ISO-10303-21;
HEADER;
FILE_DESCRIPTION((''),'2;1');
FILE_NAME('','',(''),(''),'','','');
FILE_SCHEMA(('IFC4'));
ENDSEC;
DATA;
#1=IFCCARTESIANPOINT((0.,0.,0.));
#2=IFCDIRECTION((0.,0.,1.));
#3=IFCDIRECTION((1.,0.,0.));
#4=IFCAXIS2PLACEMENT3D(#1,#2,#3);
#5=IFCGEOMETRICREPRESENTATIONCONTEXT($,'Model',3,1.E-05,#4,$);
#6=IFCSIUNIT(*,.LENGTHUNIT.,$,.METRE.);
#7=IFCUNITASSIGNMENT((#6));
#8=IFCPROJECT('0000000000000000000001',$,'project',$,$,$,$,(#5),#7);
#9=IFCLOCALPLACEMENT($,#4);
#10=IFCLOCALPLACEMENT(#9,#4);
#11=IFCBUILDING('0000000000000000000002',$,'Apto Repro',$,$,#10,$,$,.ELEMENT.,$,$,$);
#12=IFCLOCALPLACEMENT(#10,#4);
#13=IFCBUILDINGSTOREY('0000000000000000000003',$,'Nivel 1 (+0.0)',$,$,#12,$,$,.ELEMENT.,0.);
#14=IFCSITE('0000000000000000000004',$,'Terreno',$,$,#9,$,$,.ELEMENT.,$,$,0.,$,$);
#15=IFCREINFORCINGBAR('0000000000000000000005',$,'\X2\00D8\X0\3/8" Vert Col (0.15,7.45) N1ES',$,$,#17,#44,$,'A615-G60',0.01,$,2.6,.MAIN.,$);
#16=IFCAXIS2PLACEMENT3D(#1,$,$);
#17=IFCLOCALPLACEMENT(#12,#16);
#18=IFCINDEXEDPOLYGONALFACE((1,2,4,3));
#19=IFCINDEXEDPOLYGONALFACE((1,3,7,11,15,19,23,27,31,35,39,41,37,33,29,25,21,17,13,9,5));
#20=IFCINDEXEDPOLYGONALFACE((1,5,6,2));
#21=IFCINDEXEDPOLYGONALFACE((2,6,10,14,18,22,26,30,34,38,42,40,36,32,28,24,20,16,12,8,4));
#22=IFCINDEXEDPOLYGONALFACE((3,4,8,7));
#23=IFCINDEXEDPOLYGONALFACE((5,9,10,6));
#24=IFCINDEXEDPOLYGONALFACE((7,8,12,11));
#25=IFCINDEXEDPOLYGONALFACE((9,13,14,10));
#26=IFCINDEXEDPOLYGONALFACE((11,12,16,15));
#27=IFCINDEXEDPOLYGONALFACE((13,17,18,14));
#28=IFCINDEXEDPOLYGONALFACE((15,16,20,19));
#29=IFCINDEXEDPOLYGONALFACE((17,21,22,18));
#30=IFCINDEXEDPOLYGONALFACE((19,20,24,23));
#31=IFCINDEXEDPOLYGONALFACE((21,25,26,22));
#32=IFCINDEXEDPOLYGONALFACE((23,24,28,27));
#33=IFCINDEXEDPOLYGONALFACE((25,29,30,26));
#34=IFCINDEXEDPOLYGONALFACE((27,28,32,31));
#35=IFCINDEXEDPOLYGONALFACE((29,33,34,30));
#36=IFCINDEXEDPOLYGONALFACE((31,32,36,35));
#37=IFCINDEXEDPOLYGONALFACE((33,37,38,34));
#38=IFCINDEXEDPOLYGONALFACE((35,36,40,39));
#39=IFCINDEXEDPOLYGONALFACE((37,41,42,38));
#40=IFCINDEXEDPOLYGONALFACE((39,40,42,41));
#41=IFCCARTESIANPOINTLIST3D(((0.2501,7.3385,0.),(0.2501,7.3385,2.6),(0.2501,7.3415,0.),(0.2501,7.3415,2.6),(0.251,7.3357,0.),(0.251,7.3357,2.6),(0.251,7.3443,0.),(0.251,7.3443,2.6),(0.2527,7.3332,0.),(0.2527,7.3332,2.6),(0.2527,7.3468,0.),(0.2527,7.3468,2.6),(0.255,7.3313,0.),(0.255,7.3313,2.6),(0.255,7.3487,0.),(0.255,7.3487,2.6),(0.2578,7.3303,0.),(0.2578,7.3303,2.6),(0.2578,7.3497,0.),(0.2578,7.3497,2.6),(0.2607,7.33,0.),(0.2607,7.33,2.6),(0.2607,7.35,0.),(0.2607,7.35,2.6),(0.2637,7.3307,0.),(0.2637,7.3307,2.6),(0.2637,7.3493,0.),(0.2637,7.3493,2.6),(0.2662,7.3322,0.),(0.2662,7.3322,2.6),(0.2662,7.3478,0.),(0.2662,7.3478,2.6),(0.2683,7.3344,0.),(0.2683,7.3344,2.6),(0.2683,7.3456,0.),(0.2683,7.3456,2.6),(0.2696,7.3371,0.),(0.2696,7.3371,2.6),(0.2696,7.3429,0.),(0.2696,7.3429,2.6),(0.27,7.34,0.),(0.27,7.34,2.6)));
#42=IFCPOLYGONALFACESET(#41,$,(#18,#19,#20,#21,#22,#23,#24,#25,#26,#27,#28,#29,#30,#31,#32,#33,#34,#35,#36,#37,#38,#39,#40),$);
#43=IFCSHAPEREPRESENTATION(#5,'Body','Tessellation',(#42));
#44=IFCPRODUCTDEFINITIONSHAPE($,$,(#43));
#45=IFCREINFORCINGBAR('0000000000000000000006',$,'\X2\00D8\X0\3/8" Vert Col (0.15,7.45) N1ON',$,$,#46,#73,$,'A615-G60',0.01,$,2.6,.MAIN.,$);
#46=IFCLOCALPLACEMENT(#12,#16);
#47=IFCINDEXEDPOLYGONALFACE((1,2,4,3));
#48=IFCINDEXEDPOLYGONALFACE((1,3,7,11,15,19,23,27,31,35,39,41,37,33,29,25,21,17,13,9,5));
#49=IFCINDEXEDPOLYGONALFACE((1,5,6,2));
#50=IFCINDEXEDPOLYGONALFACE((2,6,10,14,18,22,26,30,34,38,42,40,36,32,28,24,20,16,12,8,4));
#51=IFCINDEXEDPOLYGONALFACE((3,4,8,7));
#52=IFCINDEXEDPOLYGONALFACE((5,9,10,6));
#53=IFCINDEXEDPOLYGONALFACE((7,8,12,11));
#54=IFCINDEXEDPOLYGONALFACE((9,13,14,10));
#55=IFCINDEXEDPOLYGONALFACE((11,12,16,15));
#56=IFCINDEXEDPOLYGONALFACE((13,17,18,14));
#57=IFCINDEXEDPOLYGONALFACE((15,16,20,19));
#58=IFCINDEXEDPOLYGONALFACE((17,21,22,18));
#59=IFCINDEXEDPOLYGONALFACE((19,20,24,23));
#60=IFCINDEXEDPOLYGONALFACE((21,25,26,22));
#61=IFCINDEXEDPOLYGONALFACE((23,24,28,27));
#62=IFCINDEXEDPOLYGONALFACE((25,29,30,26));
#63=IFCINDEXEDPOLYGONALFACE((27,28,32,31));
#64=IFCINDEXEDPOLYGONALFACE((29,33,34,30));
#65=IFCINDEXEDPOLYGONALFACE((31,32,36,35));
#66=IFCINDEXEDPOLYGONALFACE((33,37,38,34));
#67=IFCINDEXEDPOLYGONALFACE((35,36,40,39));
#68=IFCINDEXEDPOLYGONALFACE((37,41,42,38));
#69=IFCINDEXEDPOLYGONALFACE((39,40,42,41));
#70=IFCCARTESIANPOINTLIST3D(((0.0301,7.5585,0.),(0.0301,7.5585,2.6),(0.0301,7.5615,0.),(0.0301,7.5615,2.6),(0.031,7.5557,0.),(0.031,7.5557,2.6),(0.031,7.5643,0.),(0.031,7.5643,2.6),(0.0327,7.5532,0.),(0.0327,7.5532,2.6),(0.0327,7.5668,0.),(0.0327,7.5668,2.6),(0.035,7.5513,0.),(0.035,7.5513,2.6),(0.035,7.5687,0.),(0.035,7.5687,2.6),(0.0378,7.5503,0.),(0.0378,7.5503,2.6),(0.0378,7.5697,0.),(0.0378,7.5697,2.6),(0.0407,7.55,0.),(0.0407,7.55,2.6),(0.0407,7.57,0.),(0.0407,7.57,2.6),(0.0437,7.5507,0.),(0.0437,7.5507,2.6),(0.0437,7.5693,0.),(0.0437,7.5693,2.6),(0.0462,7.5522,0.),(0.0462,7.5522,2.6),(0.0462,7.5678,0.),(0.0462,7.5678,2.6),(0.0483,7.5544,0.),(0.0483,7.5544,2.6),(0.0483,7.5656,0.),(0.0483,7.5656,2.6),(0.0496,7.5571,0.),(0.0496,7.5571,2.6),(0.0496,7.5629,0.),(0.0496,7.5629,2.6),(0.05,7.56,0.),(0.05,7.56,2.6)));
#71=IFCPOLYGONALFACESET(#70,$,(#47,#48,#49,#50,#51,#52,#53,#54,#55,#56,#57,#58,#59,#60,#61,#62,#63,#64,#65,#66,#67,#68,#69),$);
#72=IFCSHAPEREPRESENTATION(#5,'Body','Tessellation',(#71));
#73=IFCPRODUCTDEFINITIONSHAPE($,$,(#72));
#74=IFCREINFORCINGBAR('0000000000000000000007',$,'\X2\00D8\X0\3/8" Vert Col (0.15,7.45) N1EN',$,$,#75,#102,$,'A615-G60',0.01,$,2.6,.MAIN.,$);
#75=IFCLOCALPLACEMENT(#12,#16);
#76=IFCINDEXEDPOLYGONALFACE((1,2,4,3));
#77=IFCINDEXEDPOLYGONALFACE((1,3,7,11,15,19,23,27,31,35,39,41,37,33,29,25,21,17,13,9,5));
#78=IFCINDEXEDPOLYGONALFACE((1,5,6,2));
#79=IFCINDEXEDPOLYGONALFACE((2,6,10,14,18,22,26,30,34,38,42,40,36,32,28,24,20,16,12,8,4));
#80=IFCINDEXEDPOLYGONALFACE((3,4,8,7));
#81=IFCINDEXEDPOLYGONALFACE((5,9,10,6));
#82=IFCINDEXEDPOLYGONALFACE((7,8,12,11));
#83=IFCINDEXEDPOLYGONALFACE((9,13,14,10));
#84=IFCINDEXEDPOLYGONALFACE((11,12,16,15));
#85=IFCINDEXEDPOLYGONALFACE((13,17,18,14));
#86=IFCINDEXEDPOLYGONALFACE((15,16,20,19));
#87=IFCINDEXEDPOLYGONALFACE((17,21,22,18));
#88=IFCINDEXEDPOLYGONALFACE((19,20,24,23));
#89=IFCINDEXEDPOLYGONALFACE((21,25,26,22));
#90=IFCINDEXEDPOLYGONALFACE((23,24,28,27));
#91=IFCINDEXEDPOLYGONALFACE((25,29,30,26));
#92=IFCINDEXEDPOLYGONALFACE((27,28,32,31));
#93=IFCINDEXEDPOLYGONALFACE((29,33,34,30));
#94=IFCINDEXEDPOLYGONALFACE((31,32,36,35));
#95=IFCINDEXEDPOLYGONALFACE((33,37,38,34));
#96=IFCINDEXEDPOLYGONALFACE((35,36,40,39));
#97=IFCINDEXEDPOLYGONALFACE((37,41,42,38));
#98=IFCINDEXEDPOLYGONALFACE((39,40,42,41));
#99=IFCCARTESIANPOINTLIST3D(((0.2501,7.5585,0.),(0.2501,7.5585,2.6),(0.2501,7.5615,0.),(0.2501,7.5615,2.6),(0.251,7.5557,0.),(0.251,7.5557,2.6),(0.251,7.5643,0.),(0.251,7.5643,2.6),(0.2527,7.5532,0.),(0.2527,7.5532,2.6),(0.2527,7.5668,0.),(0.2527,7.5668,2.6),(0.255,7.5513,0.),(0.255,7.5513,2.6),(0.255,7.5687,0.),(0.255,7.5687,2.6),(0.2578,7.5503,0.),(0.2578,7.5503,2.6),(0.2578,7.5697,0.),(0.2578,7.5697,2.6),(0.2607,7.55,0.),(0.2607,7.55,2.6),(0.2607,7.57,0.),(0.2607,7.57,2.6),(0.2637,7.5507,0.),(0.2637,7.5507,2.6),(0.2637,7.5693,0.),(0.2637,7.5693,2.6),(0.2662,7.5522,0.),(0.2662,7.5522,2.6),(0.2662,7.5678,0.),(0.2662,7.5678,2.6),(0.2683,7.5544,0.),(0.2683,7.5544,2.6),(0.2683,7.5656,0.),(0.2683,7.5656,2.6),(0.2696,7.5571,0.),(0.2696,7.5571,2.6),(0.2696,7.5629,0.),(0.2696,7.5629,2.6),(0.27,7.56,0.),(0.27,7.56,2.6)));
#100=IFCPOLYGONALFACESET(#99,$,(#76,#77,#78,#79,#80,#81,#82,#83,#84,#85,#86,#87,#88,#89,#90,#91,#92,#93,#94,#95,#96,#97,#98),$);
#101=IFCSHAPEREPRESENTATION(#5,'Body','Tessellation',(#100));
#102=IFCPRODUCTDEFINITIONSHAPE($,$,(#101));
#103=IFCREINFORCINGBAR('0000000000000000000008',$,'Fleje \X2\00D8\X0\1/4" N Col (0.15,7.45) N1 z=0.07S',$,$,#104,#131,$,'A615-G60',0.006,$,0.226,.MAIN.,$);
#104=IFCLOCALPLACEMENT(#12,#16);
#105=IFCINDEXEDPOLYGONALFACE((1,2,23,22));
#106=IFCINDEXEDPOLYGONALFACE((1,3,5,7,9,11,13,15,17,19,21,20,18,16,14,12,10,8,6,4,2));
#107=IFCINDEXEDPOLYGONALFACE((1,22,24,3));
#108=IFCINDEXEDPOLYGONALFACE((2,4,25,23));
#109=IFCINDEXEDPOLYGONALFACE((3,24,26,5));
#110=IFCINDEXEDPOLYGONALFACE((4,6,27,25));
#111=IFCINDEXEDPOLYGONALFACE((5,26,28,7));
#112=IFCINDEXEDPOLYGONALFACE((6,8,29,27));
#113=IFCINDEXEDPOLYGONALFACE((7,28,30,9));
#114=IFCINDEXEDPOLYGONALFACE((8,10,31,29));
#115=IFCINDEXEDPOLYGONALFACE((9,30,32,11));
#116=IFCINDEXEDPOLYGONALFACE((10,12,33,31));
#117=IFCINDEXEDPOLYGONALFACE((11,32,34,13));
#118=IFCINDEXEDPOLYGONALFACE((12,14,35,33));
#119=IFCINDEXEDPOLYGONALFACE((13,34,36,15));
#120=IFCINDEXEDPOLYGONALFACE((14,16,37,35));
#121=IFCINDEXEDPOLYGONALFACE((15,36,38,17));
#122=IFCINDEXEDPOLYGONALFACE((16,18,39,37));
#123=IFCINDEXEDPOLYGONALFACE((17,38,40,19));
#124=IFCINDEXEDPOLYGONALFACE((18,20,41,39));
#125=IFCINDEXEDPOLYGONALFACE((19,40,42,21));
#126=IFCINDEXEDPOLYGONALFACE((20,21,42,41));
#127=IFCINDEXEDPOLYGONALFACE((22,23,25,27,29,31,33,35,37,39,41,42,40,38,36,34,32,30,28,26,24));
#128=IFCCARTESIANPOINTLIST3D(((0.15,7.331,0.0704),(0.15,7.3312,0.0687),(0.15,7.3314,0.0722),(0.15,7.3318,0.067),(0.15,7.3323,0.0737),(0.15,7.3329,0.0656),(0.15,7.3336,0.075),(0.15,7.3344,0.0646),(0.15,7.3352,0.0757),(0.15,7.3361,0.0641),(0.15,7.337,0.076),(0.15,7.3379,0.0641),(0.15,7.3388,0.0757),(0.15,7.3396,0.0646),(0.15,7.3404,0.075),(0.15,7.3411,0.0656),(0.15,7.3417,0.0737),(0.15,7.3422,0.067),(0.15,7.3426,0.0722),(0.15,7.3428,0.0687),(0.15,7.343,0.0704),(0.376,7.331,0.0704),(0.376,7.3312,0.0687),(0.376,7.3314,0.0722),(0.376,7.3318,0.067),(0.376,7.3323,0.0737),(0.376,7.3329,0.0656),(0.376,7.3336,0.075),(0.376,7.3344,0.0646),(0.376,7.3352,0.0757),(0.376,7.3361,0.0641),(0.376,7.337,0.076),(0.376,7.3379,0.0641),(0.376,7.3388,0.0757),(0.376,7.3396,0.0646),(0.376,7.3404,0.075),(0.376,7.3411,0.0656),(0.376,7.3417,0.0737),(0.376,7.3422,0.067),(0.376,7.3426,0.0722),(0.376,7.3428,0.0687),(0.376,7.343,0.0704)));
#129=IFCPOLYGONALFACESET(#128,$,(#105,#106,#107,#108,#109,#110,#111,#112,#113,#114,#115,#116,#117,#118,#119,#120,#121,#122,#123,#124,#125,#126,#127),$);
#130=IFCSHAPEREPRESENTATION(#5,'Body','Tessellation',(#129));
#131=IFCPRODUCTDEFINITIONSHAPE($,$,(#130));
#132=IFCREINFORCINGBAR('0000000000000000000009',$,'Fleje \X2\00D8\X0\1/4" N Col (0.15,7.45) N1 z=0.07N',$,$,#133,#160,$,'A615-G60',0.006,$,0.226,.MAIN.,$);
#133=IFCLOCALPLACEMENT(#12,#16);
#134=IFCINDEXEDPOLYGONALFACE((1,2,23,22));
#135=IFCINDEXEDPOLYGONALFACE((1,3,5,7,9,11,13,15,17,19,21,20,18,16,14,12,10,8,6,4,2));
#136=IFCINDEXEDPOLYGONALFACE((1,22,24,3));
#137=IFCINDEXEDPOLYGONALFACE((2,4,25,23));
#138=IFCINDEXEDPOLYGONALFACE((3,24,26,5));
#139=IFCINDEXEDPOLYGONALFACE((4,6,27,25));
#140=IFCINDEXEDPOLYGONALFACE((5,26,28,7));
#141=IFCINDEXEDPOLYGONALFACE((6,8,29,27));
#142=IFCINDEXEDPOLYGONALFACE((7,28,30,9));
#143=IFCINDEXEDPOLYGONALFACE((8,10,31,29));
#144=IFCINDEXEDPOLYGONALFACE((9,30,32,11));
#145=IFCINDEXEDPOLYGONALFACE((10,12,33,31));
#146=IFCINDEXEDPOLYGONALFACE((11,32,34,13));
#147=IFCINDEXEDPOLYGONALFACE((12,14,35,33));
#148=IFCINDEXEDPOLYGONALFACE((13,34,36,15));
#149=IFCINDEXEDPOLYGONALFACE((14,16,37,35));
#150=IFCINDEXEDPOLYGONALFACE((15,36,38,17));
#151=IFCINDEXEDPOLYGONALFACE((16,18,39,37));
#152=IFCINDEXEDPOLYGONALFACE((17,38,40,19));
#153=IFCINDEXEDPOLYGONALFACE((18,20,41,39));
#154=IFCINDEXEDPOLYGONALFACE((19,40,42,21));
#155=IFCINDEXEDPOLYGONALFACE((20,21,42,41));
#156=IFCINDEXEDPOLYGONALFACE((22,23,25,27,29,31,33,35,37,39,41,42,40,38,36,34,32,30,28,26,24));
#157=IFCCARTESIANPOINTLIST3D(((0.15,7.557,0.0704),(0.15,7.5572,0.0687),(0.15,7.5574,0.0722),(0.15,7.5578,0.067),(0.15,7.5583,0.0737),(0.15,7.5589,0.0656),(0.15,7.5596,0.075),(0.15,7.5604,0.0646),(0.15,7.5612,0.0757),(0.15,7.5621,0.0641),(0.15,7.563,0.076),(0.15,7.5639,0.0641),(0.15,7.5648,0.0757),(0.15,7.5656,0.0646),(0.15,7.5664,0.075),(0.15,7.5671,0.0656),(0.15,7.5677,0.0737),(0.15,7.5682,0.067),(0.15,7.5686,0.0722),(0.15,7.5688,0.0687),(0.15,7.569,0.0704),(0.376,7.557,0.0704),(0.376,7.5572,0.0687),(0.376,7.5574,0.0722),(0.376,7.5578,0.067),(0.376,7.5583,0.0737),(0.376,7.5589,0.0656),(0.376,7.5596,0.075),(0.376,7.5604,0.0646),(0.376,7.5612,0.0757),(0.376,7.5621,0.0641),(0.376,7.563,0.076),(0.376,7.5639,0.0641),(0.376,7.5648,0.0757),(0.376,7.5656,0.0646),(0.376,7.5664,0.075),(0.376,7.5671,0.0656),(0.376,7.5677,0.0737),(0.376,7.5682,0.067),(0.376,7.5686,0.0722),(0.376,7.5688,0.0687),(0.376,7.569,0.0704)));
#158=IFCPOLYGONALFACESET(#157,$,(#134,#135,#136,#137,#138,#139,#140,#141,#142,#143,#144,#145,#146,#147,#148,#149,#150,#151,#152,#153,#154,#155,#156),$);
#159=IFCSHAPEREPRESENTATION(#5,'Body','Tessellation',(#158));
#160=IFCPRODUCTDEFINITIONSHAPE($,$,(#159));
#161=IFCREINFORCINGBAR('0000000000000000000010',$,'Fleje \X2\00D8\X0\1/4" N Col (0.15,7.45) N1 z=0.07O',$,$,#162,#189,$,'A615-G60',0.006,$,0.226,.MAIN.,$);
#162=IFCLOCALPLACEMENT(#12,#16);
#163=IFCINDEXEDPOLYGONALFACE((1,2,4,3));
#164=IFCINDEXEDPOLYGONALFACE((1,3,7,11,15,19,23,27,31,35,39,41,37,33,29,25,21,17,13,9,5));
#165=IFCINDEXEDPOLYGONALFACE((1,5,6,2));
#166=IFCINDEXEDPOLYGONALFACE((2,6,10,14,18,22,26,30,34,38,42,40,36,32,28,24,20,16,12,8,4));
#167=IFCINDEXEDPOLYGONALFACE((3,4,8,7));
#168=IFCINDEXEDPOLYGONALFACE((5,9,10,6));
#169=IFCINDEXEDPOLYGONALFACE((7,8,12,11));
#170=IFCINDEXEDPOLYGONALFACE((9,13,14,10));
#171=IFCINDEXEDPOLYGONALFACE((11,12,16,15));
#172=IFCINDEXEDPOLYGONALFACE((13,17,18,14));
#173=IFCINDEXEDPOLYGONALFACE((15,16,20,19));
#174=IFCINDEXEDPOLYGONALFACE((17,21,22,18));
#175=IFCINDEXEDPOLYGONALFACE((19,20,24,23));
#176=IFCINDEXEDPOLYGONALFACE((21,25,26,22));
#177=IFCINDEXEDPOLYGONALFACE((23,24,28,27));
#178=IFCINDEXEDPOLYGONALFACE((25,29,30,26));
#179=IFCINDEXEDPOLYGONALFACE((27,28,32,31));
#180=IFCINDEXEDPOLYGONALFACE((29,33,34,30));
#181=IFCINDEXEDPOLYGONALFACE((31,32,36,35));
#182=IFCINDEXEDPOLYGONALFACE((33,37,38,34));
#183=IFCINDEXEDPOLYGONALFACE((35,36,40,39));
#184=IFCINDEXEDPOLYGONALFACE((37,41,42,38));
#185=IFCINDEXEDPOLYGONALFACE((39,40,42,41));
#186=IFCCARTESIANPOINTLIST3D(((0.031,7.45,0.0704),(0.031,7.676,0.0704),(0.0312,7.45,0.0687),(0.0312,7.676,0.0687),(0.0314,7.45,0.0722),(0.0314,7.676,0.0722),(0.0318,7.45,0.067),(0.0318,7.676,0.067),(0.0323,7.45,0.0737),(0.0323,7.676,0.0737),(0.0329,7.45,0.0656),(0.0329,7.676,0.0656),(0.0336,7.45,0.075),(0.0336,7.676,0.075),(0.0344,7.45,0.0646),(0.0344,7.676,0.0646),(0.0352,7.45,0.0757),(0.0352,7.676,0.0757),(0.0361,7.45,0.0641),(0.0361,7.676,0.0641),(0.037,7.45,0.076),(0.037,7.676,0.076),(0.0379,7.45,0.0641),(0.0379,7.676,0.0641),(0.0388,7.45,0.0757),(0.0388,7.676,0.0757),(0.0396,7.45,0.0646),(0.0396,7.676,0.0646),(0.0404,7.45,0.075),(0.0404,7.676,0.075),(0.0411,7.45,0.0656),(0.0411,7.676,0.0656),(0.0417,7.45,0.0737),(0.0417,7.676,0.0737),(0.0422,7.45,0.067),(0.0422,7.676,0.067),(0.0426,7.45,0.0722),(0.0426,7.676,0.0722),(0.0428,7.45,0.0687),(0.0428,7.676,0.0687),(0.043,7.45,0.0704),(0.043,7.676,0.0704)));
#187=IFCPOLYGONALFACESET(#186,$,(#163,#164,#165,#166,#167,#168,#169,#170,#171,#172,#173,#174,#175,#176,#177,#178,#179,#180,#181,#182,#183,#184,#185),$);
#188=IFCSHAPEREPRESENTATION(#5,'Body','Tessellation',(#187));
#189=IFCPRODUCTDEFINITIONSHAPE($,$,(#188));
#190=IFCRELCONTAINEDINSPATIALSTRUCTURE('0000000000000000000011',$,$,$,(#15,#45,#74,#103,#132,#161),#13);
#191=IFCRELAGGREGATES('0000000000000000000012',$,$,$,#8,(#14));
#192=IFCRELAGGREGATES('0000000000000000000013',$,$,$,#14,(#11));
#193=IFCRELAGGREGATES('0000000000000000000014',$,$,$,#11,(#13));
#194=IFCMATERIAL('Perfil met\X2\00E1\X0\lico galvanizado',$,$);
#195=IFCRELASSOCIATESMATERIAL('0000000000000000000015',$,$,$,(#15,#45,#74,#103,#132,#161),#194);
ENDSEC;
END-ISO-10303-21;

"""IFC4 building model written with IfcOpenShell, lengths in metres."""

from ifc_helpers import new_model, si_unit, frame, origin_with_axes, origin_2d_with_axis, place, context, project, spatial, circle, extrude, material, element, save


model = new_model("IFC4")

# Units and contexts
model_context = context("Model", 3, precision=1e-05, world=origin_with_axes())
ifc_project = project(units=[si_unit("LENGTHUNIT", "METRE")], contexts=[model_context])

# Site, building, storey
site_placement = place(None, origin_with_axes())
site = spatial("IfcSite", under=ifc_project, at=site_placement, Name="Terreno", CompositionType="ELEMENT", RefElevation=0.0)
building_placement = place(site_placement, origin_with_axes())
building = spatial("IfcBuilding", under=site, at=building_placement, Name="Apto Repro", CompositionType="ELEMENT")
storey_placement = place(building_placement, origin_with_axes())
storey = spatial("IfcBuildingStorey", under=building, at=storey_placement, Name="Nivel 1 (+0.0)", CompositionType="ELEMENT", Elevation=0.0)

# Reinforcing bars
ifc_material = material(Name="Perfil metálico galvanizado")
reinforcing_bar_1_placement = place(storey_placement, origin_with_axes())
element("IfcReinforcingBar", 1, at=reinforcing_bar_1_placement, inside=storey, material=ifc_material, Name="Ø3/8\" Vert Col (0.15,7.45) N1ES", SteelGrade="A615-G60", BarLength=2.6, NominalDiameter=0.01, PredefinedType="MAIN", context=model_context, shape_type="SweptSolid", body=[
    extrude(circle(Radius=0.01, at=origin_2d_with_axis()), frame((0.26, 7.34, 0.0), z_axis=(0.0, 0.0, 1.0), x_axis=(1.0, 0.0, 0.0)), (0.0, 0.0, 1.0), 2.6),
])
reinforcing_bar_2_placement = place(storey_placement, origin_with_axes())
element("IfcReinforcingBar", 2, at=reinforcing_bar_2_placement, inside=storey, material=ifc_material, Name="Ø3/8\" Vert Col (0.15,7.45) N1ON", SteelGrade="A615-G60", BarLength=2.6, NominalDiameter=0.01, PredefinedType="MAIN", context=model_context, shape_type="SweptSolid", body=[
    extrude(circle(Radius=0.01, at=origin_2d_with_axis()), frame((0.04, 7.56, 0.0), z_axis=(0.0, 0.0, 1.0), x_axis=(1.0, 0.0, 0.0)), (0.0, 0.0, 1.0), 2.6),
])
reinforcing_bar_3_placement = place(storey_placement, origin_with_axes())
element("IfcReinforcingBar", 3, at=reinforcing_bar_3_placement, inside=storey, material=ifc_material, Name="Ø3/8\" Vert Col (0.15,7.45) N1EN", SteelGrade="A615-G60", BarLength=2.6, NominalDiameter=0.01, PredefinedType="MAIN", context=model_context, shape_type="SweptSolid", body=[
    extrude(circle(Radius=0.01, at=origin_2d_with_axis()), frame((0.26, 7.56, 0.0), z_axis=(0.0, 0.0, 1.0), x_axis=(1.0, 0.0, 0.0)), (0.0, 0.0, 1.0), 2.6),
])
reinforcing_bar_4_placement = place(storey_placement, origin_with_axes())
element("IfcReinforcingBar", 4, at=reinforcing_bar_4_placement, inside=storey, material=ifc_material, Name="Fleje Ø1/4\" N Col (0.15,7.45) N1 z=0.07S", SteelGrade="A615-G60", BarLength=0.226, NominalDiameter=0.006, PredefinedType="MAIN", context=model_context, shape_type="SweptSolid", body=[
    extrude(circle(Radius=0.006, at=origin_2d_with_axis()), frame((0.15, 7.337, 0.07), z_axis=(1.0, 0.0, 0.0), x_axis=(0.0, 0.0, 1.0)), (0.0, 0.0, 1.0), 0.226),
])
reinforcing_bar_5_placement = place(storey_placement, origin_with_axes())
element("IfcReinforcingBar", 5, at=reinforcing_bar_5_placement, inside=storey, material=ifc_material, Name="Fleje Ø1/4\" N Col (0.15,7.45) N1 z=0.07N", SteelGrade="A615-G60", BarLength=0.226, NominalDiameter=0.006, PredefinedType="MAIN", context=model_context, shape_type="SweptSolid", body=[
    extrude(circle(Radius=0.006, at=origin_2d_with_axis()), frame((0.15, 7.563, 0.07), z_axis=(1.0, 0.0, 0.0), x_axis=(0.0, 0.0, 1.0)), (0.0, 0.0, 1.0), 0.226),
])
reinforcing_bar_6_placement = place(storey_placement, origin_with_axes())
element("IfcReinforcingBar", 6, at=reinforcing_bar_6_placement, inside=storey, material=ifc_material, Name="Fleje Ø1/4\" N Col (0.15,7.45) N1 z=0.07O", SteelGrade="A615-G60", BarLength=0.226, NominalDiameter=0.006, PredefinedType="MAIN", context=model_context, shape_type="SweptSolid", body=[
    extrude(circle(Radius=0.006, at=origin_2d_with_axis()), frame((0.037, 7.45, 0.07), z_axis=(0.0, 1.0, 0.0), x_axis=(0.0, 0.0, 1.0)), (0.0, 0.0, 1.0), 0.226),
])

save(model, "model.ifc")
